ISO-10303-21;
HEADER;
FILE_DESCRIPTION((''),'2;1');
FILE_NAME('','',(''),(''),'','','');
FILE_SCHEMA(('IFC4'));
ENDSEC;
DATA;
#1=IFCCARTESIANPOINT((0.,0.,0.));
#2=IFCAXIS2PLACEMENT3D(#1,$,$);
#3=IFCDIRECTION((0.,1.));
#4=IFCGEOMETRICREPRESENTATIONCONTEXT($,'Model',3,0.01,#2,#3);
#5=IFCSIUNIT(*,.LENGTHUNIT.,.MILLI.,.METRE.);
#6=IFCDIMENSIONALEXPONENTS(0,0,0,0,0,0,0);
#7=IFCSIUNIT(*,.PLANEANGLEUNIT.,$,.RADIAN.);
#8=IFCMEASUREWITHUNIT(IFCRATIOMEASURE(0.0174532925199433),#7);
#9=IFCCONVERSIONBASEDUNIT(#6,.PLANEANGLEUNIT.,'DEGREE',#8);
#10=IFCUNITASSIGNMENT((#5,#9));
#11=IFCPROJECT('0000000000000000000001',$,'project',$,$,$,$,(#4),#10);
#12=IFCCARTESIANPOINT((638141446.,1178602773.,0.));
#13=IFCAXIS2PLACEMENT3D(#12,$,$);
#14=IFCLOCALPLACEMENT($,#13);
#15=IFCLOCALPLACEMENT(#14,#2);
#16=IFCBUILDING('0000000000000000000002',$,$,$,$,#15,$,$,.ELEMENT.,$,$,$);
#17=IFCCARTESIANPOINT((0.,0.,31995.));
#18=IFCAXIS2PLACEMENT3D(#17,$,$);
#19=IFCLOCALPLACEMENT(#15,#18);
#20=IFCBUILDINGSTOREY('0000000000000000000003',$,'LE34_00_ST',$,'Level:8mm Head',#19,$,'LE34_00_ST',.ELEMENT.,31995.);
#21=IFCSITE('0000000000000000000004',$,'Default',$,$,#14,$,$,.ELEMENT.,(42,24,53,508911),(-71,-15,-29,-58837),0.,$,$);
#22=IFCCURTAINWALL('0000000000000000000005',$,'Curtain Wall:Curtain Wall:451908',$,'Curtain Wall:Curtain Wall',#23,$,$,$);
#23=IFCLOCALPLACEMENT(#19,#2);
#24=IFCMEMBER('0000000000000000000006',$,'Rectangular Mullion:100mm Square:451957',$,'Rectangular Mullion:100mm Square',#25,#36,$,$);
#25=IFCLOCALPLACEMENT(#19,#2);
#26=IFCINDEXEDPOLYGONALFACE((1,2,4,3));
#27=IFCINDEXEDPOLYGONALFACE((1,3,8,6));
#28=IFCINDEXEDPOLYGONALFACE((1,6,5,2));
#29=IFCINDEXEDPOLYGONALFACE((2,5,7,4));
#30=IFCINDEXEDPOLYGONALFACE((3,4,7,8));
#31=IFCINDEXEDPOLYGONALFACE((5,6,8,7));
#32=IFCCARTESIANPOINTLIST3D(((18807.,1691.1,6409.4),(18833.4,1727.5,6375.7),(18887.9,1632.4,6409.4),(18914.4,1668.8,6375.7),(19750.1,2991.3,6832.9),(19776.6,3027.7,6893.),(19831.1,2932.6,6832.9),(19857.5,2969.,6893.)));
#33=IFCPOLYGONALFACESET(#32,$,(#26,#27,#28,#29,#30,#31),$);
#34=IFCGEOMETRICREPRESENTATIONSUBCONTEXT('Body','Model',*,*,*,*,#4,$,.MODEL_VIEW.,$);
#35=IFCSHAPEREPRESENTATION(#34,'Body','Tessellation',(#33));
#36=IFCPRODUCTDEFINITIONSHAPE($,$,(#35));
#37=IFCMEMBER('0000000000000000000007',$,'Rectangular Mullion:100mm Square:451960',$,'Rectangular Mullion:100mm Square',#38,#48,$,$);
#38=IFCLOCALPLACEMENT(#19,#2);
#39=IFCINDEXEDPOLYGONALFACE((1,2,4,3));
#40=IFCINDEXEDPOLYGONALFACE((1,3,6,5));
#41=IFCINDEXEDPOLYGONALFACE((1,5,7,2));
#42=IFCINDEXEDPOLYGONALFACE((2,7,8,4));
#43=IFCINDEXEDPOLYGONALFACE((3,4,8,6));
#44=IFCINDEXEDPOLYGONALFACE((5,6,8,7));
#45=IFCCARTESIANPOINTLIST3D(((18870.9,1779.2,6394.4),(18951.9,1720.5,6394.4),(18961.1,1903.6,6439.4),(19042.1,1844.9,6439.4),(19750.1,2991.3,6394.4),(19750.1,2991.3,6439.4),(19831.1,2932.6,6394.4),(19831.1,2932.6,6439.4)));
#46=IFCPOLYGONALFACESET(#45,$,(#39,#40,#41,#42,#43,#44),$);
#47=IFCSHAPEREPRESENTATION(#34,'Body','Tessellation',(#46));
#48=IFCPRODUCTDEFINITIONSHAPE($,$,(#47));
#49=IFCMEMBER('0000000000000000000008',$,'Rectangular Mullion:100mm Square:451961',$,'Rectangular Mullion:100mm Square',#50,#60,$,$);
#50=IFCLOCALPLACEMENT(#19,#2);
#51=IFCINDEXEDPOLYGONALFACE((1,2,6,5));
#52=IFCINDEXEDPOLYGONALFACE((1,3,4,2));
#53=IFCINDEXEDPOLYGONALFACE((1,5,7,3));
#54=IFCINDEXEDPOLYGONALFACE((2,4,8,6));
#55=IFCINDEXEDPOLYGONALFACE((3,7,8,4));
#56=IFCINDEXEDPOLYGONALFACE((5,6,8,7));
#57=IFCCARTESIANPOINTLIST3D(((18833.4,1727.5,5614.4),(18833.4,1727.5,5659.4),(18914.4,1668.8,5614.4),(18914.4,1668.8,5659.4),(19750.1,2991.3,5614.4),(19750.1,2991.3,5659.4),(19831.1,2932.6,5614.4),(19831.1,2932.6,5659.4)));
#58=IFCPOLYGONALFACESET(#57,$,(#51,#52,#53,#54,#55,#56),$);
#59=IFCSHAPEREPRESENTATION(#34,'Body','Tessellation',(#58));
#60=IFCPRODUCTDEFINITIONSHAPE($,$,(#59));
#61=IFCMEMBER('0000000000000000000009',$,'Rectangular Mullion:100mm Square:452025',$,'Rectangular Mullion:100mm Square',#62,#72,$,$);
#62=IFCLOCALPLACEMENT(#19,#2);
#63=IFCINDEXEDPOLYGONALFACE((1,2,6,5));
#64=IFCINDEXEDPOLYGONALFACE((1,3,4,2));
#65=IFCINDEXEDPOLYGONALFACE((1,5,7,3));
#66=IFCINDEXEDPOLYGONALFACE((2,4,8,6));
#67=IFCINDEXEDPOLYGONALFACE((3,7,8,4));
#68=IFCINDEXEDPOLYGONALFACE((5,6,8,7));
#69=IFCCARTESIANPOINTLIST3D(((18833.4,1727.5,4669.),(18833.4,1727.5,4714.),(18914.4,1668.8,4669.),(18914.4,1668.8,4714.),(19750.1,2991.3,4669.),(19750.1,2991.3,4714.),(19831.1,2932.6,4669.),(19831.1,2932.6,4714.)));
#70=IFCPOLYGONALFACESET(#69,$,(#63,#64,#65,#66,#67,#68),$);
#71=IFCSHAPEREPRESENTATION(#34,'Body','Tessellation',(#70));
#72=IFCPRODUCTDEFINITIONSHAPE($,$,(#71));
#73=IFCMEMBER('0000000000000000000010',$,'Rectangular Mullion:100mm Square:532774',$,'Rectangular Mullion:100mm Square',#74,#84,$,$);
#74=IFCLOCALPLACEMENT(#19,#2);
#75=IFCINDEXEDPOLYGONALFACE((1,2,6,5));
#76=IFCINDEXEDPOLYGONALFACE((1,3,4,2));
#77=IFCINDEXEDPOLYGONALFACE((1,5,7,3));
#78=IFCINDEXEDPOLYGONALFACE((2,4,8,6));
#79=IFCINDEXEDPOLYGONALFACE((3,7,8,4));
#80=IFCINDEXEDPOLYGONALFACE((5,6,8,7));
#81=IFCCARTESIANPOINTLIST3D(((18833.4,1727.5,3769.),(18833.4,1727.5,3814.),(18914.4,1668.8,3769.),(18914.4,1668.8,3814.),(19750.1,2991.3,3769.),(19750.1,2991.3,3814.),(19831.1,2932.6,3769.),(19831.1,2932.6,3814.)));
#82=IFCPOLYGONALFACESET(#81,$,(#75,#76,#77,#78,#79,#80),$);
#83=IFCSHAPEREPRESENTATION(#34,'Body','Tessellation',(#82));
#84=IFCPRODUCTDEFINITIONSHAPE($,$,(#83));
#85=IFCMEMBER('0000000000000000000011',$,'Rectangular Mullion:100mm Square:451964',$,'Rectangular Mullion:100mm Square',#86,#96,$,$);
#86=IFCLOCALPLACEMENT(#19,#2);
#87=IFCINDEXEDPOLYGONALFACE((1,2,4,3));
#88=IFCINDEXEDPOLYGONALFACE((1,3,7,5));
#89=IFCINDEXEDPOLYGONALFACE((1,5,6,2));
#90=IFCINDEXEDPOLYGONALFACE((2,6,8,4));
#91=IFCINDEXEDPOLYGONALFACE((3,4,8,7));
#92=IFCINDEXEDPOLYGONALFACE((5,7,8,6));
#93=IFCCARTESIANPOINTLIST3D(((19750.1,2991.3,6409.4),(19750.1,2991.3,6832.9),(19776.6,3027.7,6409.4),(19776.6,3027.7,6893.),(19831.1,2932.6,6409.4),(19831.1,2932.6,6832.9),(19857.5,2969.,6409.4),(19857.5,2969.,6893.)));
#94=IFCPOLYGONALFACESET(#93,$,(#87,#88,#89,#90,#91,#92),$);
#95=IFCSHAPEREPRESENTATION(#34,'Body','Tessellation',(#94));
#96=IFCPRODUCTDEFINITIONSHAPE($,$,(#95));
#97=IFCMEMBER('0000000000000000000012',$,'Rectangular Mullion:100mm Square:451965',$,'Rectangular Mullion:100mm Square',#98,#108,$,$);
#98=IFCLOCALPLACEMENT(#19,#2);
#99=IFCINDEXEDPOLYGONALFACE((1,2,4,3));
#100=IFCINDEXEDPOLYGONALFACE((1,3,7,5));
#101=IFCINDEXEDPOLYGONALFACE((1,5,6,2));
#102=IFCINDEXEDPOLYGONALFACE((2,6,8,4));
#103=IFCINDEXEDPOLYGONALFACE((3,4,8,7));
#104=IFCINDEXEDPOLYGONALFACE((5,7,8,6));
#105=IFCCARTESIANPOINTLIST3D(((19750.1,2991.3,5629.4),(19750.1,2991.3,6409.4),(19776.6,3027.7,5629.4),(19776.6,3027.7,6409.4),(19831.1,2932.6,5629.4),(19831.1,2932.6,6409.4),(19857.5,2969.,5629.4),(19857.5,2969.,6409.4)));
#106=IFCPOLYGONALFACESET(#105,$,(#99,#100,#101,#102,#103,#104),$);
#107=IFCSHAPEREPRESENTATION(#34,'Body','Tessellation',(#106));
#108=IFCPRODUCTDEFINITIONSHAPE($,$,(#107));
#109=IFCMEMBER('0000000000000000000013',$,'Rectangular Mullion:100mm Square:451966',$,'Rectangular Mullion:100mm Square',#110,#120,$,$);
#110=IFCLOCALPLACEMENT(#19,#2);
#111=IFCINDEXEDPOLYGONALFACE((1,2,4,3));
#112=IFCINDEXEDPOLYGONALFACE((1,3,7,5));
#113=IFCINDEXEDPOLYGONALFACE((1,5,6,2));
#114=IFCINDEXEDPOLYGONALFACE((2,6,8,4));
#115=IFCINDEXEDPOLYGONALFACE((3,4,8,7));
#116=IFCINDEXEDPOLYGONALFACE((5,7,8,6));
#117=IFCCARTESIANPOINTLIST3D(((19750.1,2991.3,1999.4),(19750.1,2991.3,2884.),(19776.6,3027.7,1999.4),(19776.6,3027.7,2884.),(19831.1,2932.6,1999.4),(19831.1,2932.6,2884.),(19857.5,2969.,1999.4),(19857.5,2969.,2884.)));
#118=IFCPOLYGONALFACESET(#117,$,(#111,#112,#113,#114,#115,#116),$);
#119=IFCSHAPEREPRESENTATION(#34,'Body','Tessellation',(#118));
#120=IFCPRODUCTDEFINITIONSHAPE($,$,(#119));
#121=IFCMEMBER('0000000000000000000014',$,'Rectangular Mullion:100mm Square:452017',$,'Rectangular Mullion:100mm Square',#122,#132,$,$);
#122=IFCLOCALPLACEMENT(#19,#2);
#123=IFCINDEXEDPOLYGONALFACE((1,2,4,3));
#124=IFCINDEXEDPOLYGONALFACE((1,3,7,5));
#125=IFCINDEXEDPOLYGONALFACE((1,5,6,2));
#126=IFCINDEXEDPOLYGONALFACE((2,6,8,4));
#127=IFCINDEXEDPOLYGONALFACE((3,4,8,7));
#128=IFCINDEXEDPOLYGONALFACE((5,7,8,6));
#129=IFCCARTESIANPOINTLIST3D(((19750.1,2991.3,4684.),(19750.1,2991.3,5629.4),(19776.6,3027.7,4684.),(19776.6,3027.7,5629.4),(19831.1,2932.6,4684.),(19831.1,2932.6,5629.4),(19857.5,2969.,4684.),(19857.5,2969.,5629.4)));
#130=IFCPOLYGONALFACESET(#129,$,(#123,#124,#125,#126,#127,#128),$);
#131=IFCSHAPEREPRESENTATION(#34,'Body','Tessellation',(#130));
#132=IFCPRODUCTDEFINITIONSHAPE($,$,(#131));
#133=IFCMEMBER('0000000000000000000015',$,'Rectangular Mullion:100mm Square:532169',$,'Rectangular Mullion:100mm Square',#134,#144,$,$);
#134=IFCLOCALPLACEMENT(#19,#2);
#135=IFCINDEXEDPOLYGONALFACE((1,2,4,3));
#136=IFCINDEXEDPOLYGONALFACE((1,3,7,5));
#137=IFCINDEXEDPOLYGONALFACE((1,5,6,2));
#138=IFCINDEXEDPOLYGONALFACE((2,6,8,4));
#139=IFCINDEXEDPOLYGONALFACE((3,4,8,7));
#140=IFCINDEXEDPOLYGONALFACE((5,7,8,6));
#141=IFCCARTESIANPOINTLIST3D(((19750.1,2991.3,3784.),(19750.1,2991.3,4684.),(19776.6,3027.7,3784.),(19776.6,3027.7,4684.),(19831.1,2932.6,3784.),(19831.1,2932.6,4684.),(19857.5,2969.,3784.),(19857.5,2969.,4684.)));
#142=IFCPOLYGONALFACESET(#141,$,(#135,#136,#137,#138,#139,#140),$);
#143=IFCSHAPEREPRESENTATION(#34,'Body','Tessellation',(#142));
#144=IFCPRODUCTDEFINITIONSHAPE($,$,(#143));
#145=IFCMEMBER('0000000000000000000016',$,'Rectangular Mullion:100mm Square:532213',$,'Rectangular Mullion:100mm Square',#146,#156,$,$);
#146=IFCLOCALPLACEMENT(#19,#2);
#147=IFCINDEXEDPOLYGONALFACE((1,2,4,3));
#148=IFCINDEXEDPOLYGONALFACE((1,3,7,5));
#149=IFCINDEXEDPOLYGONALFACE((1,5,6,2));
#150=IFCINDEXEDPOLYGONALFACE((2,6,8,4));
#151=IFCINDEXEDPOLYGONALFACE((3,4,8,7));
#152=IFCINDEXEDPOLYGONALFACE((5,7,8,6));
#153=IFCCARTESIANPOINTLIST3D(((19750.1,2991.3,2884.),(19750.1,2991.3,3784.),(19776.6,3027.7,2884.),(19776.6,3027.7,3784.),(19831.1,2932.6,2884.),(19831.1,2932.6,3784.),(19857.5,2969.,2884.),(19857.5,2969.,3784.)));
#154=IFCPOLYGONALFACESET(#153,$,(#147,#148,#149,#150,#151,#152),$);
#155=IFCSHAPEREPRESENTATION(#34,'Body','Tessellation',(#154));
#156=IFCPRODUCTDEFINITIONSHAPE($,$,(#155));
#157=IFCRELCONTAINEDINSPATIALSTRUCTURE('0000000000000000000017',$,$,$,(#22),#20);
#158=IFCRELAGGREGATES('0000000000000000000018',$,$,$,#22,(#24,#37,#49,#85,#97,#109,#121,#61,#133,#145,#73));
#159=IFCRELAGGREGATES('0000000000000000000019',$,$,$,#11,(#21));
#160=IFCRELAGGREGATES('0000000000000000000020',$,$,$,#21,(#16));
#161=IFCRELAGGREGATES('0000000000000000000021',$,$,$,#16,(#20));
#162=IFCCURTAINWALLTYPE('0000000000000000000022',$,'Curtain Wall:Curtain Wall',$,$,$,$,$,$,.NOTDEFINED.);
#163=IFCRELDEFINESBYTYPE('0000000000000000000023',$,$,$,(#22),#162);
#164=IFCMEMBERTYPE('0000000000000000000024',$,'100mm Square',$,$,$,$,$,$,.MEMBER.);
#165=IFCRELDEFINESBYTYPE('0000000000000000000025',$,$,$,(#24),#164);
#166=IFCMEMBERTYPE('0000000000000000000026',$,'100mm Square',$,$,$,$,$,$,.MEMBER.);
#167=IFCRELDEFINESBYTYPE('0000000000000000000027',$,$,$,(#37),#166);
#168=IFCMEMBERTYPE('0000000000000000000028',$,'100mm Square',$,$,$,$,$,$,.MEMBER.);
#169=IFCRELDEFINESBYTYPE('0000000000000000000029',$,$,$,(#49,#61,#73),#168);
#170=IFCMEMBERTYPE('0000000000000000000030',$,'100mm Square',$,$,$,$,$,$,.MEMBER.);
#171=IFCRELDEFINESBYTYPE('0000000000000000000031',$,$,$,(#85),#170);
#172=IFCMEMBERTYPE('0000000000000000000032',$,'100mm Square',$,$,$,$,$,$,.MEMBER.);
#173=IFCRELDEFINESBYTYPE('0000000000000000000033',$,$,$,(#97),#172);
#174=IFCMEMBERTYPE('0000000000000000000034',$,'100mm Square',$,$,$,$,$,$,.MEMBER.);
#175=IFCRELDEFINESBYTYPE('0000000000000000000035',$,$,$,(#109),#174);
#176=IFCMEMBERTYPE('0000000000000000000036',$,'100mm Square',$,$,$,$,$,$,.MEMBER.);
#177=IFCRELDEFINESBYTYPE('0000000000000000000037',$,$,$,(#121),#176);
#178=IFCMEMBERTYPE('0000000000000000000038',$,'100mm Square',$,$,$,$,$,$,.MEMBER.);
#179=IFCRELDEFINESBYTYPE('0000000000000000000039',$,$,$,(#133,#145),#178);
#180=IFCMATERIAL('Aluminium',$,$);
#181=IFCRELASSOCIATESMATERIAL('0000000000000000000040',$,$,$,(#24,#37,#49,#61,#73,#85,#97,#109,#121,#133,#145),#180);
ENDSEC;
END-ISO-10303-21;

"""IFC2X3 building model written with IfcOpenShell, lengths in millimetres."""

from ifc_helpers import new_model, entity, si_unit, converted_unit, direction, frame, frame_2d, origin, origin_2d_with_axis, place, context, subcontext, project, spatial, rectangle, extrude, clip, halfspace, source, transform, mapped, material, type_object, type_shapes, element, aggregate, save


model = new_model("IFC2X3")

# Units and contexts
model_context = context("Model", 3, precision=0.01, world=origin(), true_north=direction((0.0, 1.0)))
body_context = subcontext(model_context, "Body", "Model", "MODEL_VIEW")
ifc_project = project(units=[si_unit("LENGTHUNIT", "METRE", prefix="MILLI"), converted_unit("PLANEANGLEUNIT", "DEGREE", entity("IfcRatioMeasure", 0.0174532925199433), si_unit("PLANEANGLEUNIT", "RADIAN"), dimensions=[0, 0, 0, 0, 0, 0, 0])], contexts=[model_context])

# Site, building, storey
site_placement = place(None, frame((638141446.0, 1178602773.0, 0.0)))
site = spatial("IfcSite", under=ifc_project, at=site_placement, Name="Default", CompositionType="ELEMENT", RefLatitude=(42, 24, 53, 508911), RefLongitude=(-71, -15, -29, -58837), RefElevation=0.0)
building_placement = place(site_placement, origin())
building = spatial("IfcBuilding", under=site, at=building_placement, CompositionType="ELEMENT")
storey_placement = place(building_placement, frame((0.0, 0.0, 31995.0)))
storey = spatial("IfcBuildingStorey", under=building, at=storey_placement, Name="LE34_00_ST", ObjectType="Level:8mm Head", LongName="LE34_00_ST", CompositionType="ELEMENT", Elevation=31995.0)

# Curtain wall, members
curtain_wall_type = type_object("IfcCurtainWallType", Name="Curtain Wall:Curtain Wall", PredefinedType="NOTDEFINED")
curtain_wall_placement = place(storey_placement, frame((0.0, 0.0, -31995.0)))
curtain_wall = element("IfcCurtainWall", 1, at=curtain_wall_placement, inside=storey, type_object=curtain_wall_type, Name="Curtain Wall:Curtain Wall:451908", ObjectType="Curtain Wall:Curtain Wall")
ifc_material_1 = material(Name="Aluminium")
member_type_1 = type_object("IfcMemberType", Name="100mm Square", PredefinedType="MEMBER")
shared_shape_1 = source(origin(), body_context, "Body", "Clipping", [
    clip(clip(extrude(rectangle(XDim=100.0, YDim=45.0, at=frame_2d((0.0, 0.0), x_axis=(1.0, 0.0))), frame((-22.5, 0.0, -1720.6), z_axis=(0.0, 0.0, 1.0), x_axis=(0.0, -1.0, 0.0)), (0.0, 0.0, 1.0), 1720.6), halfspace(frame((0.0, -304.8, -1720.6), z_axis=(-0.599555, 0.0, -0.800333), x_axis=(-0.800333, 0.0, 0.599555)), False)), halfspace(frame((0.0, -304.8, 0.0), z_axis=(-0.800333, 0.0, 0.599555), x_axis=(-0.599555, 0.0, -0.800333)), False)),
])
type_shapes(member_type_1, [shared_shape_1])
member_1_placement = place(storey_placement, frame((19817.0, 2998.4, 6893.0), z_axis=(0.563495, 0.776837, 0.281067), x_axis=(-0.165032, -0.227515, 0.959688)))
member_1 = element("IfcMember", 2, at=member_1_placement, type_object=member_type_1, material=ifc_material_1, Name="Rectangular Mullion:100mm Square:451957", ObjectType="Rectangular Mullion:100mm Square", context=body_context, shape_type="MappedRepresentation", body=[
    mapped(shared_shape_1, transform((0.0, 0.0, 0.0), scale=1.0)),
])
member_type_2 = type_object("IfcMemberType", Name="100mm Square", PredefinedType="MEMBER")
shared_shape_2 = source(origin(), body_context, "Body", "Clipping", [
    clip(extrude(rectangle(XDim=100.0, YDim=45.0, at=origin_2d_with_axis()), frame((7.5, 0.0, -1497.4), z_axis=(0.0, 0.0, 1.0), x_axis=(0.0, -1.0, 0.0)), (0.0, 0.0, 1.0), 1497.4), halfspace(frame((440.4, 50.0, 57.6), z_axis=(0.959688, 0.0, -0.281067), x_axis=(-0.281067, 0.0, -0.959688)), False)),
])
type_shapes(member_type_2, [shared_shape_2])
member_2_placement = place(storey_placement, frame((19790.6, 2962.0, 6409.4), z_axis=(0.587164, 0.809468, 0.0), x_axis=(0.0, 0.0, 1.0)))
member_2 = element("IfcMember", 3, at=member_2_placement, type_object=member_type_2, material=ifc_material_1, Name="Rectangular Mullion:100mm Square:451960", ObjectType="Rectangular Mullion:100mm Square", context=body_context, shape_type="MappedRepresentation", body=[
    mapped(shared_shape_2, transform((0.0, 0.0, 0.0), scale=1.0)),
])
member_type_3 = type_object("IfcMemberType", Name="100mm Square", PredefinedType="MEMBER")
shared_shape_3 = source(origin(), body_context, "Body", "SweptSolid", [
    extrude(rectangle(XDim=100.0, YDim=45.0, at=origin_2d_with_axis()), frame((7.5, 0.0, -1561.3), z_axis=(0.0, 0.0, 1.0), x_axis=(0.0, -1.0, 0.0)), (0.0, 0.0, 1.0), 1561.3),
])
type_shapes(member_type_3, [shared_shape_3])
member_3_placement = place(storey_placement, frame((19790.6, 2962.0, 5629.4), z_axis=(0.587164, 0.809468, 0.0), x_axis=(0.0, 0.0, 1.0)))
member_3 = element("IfcMember", 4, at=member_3_placement, type_object=member_type_3, material=ifc_material_1, Name="Rectangular Mullion:100mm Square:451961", ObjectType="Rectangular Mullion:100mm Square", context=body_context, shape_type="MappedRepresentation", body=[
    mapped(shared_shape_3, transform((0.0, 0.0, 0.0), scale=1.0)),
])
member_4_placement = place(storey_placement, frame((19790.6, 2962.0, 4684.0), z_axis=(0.587164, 0.809468, 0.0), x_axis=(0.0, 0.0, 1.0)))
member_4 = element("IfcMember", 5, at=member_4_placement, type_object=member_type_3, material=ifc_material_1, Name="Rectangular Mullion:100mm Square:452025", ObjectType="Rectangular Mullion:100mm Square", context=body_context, shape_type="MappedRepresentation", body=[
    mapped(shared_shape_3, transform((0.0, 0.0, 0.0), scale=1.0)),
])
member_5_placement = place(storey_placement, frame((19790.6, 2962.0, 3784.0), z_axis=(0.587164, 0.809468, 0.0), x_axis=(0.0, 0.0, 1.0)))
member_5 = element("IfcMember", 6, at=member_5_placement, type_object=member_type_3, material=ifc_material_1, Name="Rectangular Mullion:100mm Square:532774", ObjectType="Rectangular Mullion:100mm Square", context=body_context, shape_type="MappedRepresentation", body=[
    mapped(shared_shape_3, transform((0.0, 0.0, 0.0), scale=1.0)),
])
member_type_4 = type_object("IfcMemberType", Name="100mm Square", PredefinedType="MEMBER")
shared_shape_4 = source(origin(), body_context, "Body", "Clipping", [
    clip(extrude(rectangle(XDim=100.0, YDim=45.0, at=origin_2d_with_axis()), frame((-22.5, 0.0, -483.6), z_axis=(0.0, 0.0, 1.0), x_axis=(0.0, -1.0, 0.0)), (0.0, 0.0, 1.0), 483.6), halfspace(frame((0.0, -304.8, -483.6), z_axis=(-0.800333, 0.0, -0.599555), x_axis=(-0.599555, 0.0, 0.800333)), False)),
])
type_shapes(member_type_4, [shared_shape_4])
member_6_placement = place(storey_placement, frame((19817.0, 2998.4, 6409.4), z_axis=(0.0, 0.0, -1.0), x_axis=(0.587164, 0.809468, 0.0)))
member_6 = element("IfcMember", 7, at=member_6_placement, type_object=member_type_4, material=ifc_material_1, Name="Rectangular Mullion:100mm Square:451964", ObjectType="Rectangular Mullion:100mm Square", context=body_context, shape_type="MappedRepresentation", body=[
    mapped(shared_shape_4, transform((0.0, 0.0, 0.0), scale=1.0)),
])
member_type_5 = type_object("IfcMemberType", Name="100mm Square", PredefinedType="MEMBER")
shared_shape_5 = source(origin(), body_context, "Body", "SweptSolid", [
    extrude(rectangle(XDim=100.0, YDim=45.0, at=origin_2d_with_axis()), frame((-22.5, 0.0, -780.0), z_axis=(0.0, 0.0, 1.0), x_axis=(0.0, -1.0, 0.0)), (0.0, 0.0, 1.0), 780.0),
])
type_shapes(member_type_5, [shared_shape_5])
member_7_placement = place(storey_placement, frame((19817.0, 2998.4, 5629.4), z_axis=(0.0, 0.0, -1.0), x_axis=(0.587164, 0.809468, 0.0)))
member_7 = element("IfcMember", 8, at=member_7_placement, type_object=member_type_5, material=ifc_material_1, Name="Rectangular Mullion:100mm Square:451965", ObjectType="Rectangular Mullion:100mm Square", context=body_context, shape_type="MappedRepresentation", body=[
    mapped(shared_shape_5, transform((0.0, 0.0, 0.0), scale=1.0)),
])
member_type_6 = type_object("IfcMemberType", Name="100mm Square", PredefinedType="MEMBER")
shared_shape_6 = source(origin(), body_context, "Body", "SweptSolid", [
    extrude(rectangle(XDim=100.0, YDim=45.0, at=origin_2d_with_axis()), frame((-22.5, 0.0, -884.6), z_axis=(0.0, 0.0, 1.0), x_axis=(0.0, -1.0, 0.0)), (0.0, 0.0, 1.0), 884.6),
])
type_shapes(member_type_6, [shared_shape_6])
member_8_placement = place(storey_placement, frame((19817.0, 2998.4, 1999.4), z_axis=(0.0, 0.0, -1.0), x_axis=(0.587164, 0.809468, 0.0)))
member_8 = element("IfcMember", 9, at=member_8_placement, type_object=member_type_6, material=ifc_material_1, Name="Rectangular Mullion:100mm Square:451966", ObjectType="Rectangular Mullion:100mm Square", context=body_context, shape_type="MappedRepresentation", body=[
    mapped(shared_shape_6, transform((0.0, 0.0, 0.0), scale=1.0)),
])
member_type_7 = type_object("IfcMemberType", Name="100mm Square", PredefinedType="MEMBER")
shared_shape_7 = source(origin(), body_context, "Body", "SweptSolid", [
    extrude(rectangle(XDim=100.0, YDim=45.0, at=origin_2d_with_axis()), frame((-22.5, 0.0, -945.4), z_axis=(0.0, 0.0, 1.0), x_axis=(0.0, -1.0, 0.0)), (0.0, 0.0, 1.0), 945.4),
])
type_shapes(member_type_7, [shared_shape_7])
member_9_placement = place(storey_placement, frame((19817.0, 2998.4, 4684.0), z_axis=(0.0, 0.0, -1.0), x_axis=(0.587164, 0.809468, 0.0)))
member_9 = element("IfcMember", 10, at=member_9_placement, type_object=member_type_7, material=ifc_material_1, Name="Rectangular Mullion:100mm Square:452017", ObjectType="Rectangular Mullion:100mm Square", context=body_context, shape_type="MappedRepresentation", body=[
    mapped(shared_shape_7, transform((0.0, 0.0, 0.0), scale=1.0)),
])
member_type_8 = type_object("IfcMemberType", Name="100mm Square", PredefinedType="MEMBER")
shared_shape_8 = source(origin(), body_context, "Body", "SweptSolid", [
    extrude(rectangle(XDim=100.0, YDim=45.0, at=origin_2d_with_axis()), frame((-22.5, 0.0, -900.0), z_axis=(0.0, 0.0, 1.0), x_axis=(0.0, -1.0, 0.0)), (0.0, 0.0, 1.0), 900.0),
])
type_shapes(member_type_8, [shared_shape_8])
member_10_placement = place(storey_placement, frame((19817.0, 2998.4, 3784.0), z_axis=(0.0, 0.0, -1.0), x_axis=(0.587164, 0.809468, 0.0)))
member_10 = element("IfcMember", 11, at=member_10_placement, type_object=member_type_8, material=ifc_material_1, Name="Rectangular Mullion:100mm Square:532169", ObjectType="Rectangular Mullion:100mm Square", context=body_context, shape_type="MappedRepresentation", body=[
    mapped(shared_shape_8, transform((0.0, 0.0, 0.0), scale=1.0)),
])
member_11_placement = place(storey_placement, frame((19817.0, 2998.4, 2884.0), z_axis=(0.0, 0.0, -1.0), x_axis=(0.587164, 0.809468, 0.0)))
member_11 = element("IfcMember", 12, at=member_11_placement, type_object=member_type_8, material=ifc_material_1, Name="Rectangular Mullion:100mm Square:532213", ObjectType="Rectangular Mullion:100mm Square", context=body_context, shape_type="MappedRepresentation", body=[
    mapped(shared_shape_8, transform((0.0, 0.0, 0.0), scale=1.0)),
])
aggregate(curtain_wall, [member_1, member_2, member_3, member_6, member_7, member_8, member_9, member_4, member_10, member_11, member_5])

save(model, "model.ifc")
